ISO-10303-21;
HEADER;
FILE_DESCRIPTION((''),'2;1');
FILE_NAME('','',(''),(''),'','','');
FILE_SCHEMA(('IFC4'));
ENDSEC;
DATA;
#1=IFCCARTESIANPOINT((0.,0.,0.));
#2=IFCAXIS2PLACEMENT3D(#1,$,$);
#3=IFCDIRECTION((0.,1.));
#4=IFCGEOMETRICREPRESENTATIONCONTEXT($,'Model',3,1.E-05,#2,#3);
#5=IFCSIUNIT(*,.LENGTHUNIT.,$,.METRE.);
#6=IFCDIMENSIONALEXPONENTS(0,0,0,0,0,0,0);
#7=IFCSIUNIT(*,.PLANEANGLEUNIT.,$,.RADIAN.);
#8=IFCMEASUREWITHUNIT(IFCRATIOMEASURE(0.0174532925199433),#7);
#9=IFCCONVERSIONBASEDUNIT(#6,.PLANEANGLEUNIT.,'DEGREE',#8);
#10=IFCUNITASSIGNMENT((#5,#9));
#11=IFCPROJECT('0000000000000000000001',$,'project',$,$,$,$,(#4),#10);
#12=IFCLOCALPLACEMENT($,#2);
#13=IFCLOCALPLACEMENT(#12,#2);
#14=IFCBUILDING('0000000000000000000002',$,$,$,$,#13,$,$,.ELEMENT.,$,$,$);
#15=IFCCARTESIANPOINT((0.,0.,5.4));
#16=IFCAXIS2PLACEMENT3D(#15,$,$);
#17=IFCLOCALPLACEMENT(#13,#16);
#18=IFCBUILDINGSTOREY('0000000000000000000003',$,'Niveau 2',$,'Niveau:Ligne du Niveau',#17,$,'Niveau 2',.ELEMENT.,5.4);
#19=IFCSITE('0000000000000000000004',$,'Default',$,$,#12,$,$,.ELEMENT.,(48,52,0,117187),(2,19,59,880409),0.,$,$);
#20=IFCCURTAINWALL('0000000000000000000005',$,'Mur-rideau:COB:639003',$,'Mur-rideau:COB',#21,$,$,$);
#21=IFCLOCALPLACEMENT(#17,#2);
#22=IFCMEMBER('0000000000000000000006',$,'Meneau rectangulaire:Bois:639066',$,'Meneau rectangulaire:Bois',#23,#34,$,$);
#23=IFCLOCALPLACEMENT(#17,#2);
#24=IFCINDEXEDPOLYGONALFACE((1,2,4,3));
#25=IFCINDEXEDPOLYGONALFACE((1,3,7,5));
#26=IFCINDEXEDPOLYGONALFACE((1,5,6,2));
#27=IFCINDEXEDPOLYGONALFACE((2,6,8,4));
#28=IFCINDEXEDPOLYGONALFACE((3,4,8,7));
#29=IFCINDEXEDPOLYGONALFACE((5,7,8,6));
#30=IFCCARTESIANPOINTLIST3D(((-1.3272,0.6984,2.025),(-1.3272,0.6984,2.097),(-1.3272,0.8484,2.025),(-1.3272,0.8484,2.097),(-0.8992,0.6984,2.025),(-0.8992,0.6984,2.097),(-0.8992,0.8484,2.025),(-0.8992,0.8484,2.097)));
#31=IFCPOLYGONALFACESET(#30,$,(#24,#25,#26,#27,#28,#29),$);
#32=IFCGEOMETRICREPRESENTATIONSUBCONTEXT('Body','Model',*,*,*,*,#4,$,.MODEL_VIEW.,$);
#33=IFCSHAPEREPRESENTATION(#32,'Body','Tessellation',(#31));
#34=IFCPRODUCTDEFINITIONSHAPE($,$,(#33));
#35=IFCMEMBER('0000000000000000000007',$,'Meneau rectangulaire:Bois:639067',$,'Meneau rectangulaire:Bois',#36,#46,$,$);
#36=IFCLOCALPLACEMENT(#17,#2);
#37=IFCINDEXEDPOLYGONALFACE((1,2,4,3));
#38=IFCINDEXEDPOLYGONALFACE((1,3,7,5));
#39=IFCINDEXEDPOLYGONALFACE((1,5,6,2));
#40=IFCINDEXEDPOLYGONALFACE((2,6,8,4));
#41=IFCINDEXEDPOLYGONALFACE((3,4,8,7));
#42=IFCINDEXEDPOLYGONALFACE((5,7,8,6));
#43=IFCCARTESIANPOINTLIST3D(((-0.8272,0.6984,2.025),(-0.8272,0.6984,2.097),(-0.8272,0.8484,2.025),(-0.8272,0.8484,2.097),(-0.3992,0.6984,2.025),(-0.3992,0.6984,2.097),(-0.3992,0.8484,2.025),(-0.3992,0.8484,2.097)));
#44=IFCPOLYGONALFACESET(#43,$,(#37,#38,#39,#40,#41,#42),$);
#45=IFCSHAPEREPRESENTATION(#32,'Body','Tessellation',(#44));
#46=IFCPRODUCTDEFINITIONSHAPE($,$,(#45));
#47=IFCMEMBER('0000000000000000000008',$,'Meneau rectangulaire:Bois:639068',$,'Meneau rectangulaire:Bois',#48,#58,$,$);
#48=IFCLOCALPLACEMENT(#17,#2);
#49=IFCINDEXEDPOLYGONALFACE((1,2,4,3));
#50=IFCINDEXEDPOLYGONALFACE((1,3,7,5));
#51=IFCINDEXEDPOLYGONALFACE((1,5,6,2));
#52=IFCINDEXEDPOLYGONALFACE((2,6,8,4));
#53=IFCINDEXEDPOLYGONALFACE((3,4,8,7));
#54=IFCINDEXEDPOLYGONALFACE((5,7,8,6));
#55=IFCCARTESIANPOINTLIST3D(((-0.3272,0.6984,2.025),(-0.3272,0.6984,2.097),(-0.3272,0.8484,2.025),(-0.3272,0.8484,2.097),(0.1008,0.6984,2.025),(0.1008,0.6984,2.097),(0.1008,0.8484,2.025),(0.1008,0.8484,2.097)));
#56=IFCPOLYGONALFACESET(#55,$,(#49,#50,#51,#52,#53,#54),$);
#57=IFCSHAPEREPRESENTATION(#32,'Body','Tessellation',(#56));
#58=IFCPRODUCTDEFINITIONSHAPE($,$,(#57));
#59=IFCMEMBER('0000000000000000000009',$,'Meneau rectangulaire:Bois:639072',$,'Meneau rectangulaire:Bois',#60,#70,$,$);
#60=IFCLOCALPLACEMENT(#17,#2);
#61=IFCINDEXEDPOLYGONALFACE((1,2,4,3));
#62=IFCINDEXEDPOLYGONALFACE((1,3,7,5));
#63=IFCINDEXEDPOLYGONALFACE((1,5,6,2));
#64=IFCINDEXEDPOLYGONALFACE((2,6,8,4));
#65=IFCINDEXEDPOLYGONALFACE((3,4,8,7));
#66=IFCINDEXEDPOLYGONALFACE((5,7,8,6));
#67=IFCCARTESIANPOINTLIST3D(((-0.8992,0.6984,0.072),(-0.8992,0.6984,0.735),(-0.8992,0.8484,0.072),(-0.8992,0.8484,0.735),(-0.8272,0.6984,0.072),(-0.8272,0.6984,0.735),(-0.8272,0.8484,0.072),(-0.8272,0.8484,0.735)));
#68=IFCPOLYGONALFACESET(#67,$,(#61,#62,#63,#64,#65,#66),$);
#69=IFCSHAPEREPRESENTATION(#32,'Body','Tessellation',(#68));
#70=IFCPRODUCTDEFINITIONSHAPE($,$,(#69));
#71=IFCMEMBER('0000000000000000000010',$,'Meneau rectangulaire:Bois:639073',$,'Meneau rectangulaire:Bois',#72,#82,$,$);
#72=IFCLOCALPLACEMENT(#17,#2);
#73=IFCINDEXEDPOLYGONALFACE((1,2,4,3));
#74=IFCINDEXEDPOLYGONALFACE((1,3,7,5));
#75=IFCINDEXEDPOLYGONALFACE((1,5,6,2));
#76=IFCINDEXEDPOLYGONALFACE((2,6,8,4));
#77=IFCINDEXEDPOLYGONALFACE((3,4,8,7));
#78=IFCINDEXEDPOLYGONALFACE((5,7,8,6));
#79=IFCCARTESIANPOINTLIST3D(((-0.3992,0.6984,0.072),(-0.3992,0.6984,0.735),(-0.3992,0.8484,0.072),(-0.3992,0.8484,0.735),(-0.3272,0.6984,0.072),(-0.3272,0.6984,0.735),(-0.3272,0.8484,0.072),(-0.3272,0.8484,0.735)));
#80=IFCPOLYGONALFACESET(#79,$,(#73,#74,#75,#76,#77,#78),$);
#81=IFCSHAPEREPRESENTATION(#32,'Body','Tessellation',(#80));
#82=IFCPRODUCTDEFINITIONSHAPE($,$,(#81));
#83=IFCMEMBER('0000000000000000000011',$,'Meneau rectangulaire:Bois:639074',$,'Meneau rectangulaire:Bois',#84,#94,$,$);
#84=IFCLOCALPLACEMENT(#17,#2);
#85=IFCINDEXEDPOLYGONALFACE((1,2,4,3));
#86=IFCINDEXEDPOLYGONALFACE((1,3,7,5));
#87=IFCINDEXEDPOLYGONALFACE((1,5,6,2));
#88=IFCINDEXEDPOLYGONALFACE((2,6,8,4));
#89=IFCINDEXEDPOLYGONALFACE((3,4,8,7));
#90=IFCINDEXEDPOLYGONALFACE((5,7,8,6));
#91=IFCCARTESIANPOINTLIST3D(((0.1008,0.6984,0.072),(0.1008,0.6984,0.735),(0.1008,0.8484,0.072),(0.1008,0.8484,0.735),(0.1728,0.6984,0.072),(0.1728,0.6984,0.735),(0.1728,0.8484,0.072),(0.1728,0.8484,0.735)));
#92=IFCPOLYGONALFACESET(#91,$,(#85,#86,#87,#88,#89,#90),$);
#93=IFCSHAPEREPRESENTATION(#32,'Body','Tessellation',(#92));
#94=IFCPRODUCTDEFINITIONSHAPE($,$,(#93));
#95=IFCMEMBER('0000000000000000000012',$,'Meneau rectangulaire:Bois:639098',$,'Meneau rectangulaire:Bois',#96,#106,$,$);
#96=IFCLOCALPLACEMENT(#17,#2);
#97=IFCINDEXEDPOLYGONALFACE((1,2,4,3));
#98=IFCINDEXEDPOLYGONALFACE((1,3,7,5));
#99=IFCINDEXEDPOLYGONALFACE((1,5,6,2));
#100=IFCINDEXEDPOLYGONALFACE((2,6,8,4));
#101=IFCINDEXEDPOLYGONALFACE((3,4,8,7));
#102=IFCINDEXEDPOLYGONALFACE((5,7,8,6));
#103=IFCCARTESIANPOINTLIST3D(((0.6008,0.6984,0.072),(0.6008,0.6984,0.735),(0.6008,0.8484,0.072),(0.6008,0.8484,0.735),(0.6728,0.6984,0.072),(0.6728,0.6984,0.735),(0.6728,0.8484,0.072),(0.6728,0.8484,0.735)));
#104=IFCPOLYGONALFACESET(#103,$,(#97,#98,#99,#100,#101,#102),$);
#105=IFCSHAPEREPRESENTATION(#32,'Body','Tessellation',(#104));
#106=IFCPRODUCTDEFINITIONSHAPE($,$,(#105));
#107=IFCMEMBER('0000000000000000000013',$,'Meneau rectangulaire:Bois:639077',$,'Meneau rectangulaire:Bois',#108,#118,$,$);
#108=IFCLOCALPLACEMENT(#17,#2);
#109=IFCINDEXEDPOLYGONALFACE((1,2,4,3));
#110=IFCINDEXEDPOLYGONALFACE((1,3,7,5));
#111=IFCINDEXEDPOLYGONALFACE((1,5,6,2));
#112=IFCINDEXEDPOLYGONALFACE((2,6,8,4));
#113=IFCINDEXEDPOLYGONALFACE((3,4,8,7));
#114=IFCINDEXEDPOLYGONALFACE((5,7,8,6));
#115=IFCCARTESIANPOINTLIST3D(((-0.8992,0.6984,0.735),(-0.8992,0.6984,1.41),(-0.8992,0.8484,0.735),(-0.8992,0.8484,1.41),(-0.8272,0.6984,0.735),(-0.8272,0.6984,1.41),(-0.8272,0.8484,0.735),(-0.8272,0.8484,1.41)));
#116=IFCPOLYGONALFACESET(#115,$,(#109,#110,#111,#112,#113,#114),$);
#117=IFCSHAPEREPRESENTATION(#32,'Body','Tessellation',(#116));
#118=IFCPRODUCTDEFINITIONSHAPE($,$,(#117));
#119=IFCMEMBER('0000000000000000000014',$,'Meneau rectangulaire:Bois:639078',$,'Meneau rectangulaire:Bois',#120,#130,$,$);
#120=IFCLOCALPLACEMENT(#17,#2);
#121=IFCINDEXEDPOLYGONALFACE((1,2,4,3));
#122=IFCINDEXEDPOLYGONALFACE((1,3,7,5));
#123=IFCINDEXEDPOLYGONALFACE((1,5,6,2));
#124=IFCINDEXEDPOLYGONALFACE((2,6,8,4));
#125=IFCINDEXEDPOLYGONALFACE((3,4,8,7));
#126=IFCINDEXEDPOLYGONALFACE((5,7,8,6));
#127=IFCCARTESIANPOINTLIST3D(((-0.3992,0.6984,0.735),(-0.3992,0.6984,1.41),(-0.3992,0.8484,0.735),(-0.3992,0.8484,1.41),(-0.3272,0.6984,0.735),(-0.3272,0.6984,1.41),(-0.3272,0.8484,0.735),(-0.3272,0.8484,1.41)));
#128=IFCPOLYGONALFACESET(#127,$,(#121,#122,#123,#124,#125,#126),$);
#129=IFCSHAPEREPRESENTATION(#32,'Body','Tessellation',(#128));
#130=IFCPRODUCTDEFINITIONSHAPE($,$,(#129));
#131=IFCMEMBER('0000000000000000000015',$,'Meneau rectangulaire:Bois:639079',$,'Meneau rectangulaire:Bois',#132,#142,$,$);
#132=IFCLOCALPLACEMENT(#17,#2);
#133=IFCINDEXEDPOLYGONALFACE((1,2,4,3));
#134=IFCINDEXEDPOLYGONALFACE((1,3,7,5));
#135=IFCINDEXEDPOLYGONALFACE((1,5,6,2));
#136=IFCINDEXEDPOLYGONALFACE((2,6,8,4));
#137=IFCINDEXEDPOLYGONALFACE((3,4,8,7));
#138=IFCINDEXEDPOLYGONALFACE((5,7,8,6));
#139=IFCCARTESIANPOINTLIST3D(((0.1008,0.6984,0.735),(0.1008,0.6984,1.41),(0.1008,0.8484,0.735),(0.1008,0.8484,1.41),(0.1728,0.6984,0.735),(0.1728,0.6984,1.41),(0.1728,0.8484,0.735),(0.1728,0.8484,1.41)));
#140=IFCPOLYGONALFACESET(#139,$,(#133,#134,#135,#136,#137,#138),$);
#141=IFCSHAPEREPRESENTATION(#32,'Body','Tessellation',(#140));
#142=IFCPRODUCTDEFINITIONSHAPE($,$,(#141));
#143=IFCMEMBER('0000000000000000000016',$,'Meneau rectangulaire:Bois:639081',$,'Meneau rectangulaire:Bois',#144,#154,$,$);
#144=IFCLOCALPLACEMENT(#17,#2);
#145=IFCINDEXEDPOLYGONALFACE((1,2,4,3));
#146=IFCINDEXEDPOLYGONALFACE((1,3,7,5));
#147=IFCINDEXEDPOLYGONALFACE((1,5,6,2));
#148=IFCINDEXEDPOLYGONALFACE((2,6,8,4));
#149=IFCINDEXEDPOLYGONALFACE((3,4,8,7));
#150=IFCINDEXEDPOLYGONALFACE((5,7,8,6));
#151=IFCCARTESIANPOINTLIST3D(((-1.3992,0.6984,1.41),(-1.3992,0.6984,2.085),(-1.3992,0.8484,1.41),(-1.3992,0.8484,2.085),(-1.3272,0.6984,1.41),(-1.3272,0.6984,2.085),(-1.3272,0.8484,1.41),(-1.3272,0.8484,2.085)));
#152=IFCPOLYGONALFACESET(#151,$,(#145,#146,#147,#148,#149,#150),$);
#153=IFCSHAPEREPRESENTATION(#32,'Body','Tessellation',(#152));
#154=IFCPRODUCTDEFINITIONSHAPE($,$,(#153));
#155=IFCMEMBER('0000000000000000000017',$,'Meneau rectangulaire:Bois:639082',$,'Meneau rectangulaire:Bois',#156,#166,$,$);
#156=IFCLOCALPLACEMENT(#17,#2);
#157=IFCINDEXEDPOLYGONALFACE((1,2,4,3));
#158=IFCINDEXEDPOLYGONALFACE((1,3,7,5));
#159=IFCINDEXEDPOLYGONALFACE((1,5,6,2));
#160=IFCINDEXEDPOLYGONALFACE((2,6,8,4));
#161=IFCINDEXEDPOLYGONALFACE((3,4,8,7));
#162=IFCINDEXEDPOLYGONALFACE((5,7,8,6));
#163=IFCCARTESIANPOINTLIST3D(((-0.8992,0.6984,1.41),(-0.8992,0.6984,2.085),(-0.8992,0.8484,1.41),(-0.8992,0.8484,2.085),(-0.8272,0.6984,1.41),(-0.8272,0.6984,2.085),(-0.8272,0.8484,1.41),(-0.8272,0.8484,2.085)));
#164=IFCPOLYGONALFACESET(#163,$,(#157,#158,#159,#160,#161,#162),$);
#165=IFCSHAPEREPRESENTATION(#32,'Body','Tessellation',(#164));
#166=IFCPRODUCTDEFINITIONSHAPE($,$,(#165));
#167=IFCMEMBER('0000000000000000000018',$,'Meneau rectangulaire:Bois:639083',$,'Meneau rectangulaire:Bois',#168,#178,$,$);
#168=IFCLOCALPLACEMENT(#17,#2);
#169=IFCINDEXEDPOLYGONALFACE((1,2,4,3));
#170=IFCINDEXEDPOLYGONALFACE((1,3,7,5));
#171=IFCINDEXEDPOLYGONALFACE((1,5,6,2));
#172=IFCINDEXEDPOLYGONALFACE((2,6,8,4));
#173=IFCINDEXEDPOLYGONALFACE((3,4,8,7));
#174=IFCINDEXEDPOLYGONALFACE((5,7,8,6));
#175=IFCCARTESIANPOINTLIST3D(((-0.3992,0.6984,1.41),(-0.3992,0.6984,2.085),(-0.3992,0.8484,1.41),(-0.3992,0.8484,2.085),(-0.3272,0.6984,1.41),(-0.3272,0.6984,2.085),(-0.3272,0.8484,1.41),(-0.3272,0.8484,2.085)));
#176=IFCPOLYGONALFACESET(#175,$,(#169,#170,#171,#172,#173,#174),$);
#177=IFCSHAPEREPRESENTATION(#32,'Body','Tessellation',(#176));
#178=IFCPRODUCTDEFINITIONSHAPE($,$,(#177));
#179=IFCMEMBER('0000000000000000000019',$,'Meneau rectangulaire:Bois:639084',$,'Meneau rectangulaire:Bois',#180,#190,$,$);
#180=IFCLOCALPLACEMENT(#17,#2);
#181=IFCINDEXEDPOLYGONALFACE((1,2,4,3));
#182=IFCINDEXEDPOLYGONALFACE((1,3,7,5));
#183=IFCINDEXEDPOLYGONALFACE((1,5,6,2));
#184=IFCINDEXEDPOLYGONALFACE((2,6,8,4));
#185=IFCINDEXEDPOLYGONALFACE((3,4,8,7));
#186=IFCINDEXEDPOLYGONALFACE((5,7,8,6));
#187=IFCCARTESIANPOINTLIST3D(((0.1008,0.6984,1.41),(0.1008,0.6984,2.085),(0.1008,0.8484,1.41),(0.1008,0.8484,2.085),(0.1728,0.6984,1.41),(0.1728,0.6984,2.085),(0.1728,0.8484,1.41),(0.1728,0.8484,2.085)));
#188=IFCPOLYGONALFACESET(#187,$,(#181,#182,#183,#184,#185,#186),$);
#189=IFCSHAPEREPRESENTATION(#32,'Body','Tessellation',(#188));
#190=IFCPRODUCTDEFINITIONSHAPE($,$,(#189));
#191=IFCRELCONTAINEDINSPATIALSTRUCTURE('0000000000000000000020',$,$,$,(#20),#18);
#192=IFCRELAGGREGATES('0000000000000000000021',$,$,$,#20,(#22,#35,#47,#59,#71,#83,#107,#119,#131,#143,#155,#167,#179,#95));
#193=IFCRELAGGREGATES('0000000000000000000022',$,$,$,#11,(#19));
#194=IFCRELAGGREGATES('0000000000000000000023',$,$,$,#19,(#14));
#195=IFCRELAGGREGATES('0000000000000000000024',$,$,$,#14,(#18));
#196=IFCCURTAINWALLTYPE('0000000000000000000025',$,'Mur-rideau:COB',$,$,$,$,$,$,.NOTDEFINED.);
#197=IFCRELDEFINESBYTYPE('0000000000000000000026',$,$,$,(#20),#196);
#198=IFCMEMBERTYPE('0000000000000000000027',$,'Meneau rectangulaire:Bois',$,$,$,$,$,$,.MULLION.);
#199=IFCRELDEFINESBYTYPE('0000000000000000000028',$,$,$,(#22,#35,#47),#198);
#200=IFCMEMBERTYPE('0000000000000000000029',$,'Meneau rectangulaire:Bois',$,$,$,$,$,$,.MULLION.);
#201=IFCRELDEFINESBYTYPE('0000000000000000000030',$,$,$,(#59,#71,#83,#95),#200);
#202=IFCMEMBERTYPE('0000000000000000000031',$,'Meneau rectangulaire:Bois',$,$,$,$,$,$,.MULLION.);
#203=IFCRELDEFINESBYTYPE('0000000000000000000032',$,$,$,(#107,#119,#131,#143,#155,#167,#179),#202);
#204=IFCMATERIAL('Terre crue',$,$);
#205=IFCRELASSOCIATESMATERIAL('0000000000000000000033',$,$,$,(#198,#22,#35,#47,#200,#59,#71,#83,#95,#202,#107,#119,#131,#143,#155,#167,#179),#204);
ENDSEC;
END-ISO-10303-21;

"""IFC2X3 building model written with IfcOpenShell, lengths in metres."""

from ifc_helpers import new_model, entity, si_unit, converted_unit, direction, frame, origin, origin_2d_with_axis, place, context, subcontext, project, spatial, rectangle, extrude, source, transform, mapped, material, type_object, type_shapes, element, aggregate, save


model = new_model("IFC2X3")

# Units and contexts
model_context = context("Model", 3, precision=1e-05, world=origin(), true_north=direction((0.0, 1.0)))
body_context = subcontext(model_context, "Body", "Model", "MODEL_VIEW")
ifc_project = project(units=[si_unit("LENGTHUNIT", "METRE"), converted_unit("PLANEANGLEUNIT", "DEGREE", entity("IfcRatioMeasure", 0.0174532925199433), si_unit("PLANEANGLEUNIT", "RADIAN"), dimensions=[0, 0, 0, 0, 0, 0, 0])], contexts=[model_context])

# Site, building, storey
site_placement = place(None, origin())
site = spatial("IfcSite", under=ifc_project, at=site_placement, Name="Default", CompositionType="ELEMENT", RefLatitude=(48, 52, 0, 117187), RefLongitude=(2, 19, 59, 880409), RefElevation=0.0)
building_placement = place(site_placement, origin())
building = spatial("IfcBuilding", under=site, at=building_placement, CompositionType="ELEMENT")
storey_placement = place(building_placement, frame((0.0, 0.0, 5.4)))
storey = spatial("IfcBuildingStorey", under=building, at=storey_placement, Name="Niveau 2", ObjectType="Niveau:Ligne du Niveau", LongName="Niveau 2", CompositionType="ELEMENT", Elevation=5.4)

# Curtain wall, members
curtain_wall_type_1 = type_object("IfcCurtainWallType", Name="Mur-rideau:COB", PredefinedType="NOTDEFINED")
curtain_wall_1_placement = place(storey_placement, frame((0.0, 0.0, -5.4)))
curtain_wall_1 = element("IfcCurtainWall", 1, at=curtain_wall_1_placement, inside=storey, type_object=curtain_wall_type_1, Name="Mur-rideau:COB:639003", ObjectType="Mur-rideau:COB")
ifc_material_1 = material(Name="Terre crue")
member_type_1 = type_object("IfcMemberType", Name="Meneau rectangulaire:Bois", PredefinedType="MULLION", material=ifc_material_1)
shared_shape_1 = source(origin(), body_context, "Body", "SweptSolid", [
    extrude(rectangle(XDim=0.15, YDim=0.072, at=origin_2d_with_axis()), frame((-0.024, 0.0, -0.428), z_axis=(0.0, 0.0, 1.0), x_axis=(0.0, -1.0, 0.0)), (0.0, 0.0, 1.0), 0.428),
])
type_shapes(member_type_1, [shared_shape_1])
member_1_placement = place(storey_placement, frame((-0.8992, 0.7734, 2.085), z_axis=(1.0, 0.0, 0.0), x_axis=(0.0, 0.0, 1.0)))
member_1 = element("IfcMember", 2, at=member_1_placement, type_object=member_type_1, material=ifc_material_1, Name="Meneau rectangulaire:Bois:639066", ObjectType="Meneau rectangulaire:Bois", context=body_context, shape_type="MappedRepresentation", body=[
    mapped(shared_shape_1, transform((0.0, 0.0, 0.0), scale=1.0)),
])
member_2_placement = place(storey_placement, frame((-0.3992, 0.7734, 2.085), z_axis=(1.0, 0.0, 0.0), x_axis=(0.0, 0.0, 1.0)))
member_2 = element("IfcMember", 3, at=member_2_placement, type_object=member_type_1, material=ifc_material_1, Name="Meneau rectangulaire:Bois:639067", ObjectType="Meneau rectangulaire:Bois", context=body_context, shape_type="MappedRepresentation", body=[
    mapped(shared_shape_1, transform((0.0, 0.0, 0.0), scale=1.0)),
])
member_3_placement = place(storey_placement, frame((0.1008, 0.7734, 2.085), z_axis=(1.0, 0.0, 0.0), x_axis=(0.0, 0.0, 1.0)))
member_3 = element("IfcMember", 4, at=member_3_placement, type_object=member_type_1, material=ifc_material_1, Name="Meneau rectangulaire:Bois:639068", ObjectType="Meneau rectangulaire:Bois", context=body_context, shape_type="MappedRepresentation", body=[
    mapped(shared_shape_1, transform((0.0, 0.0, 0.0), scale=1.0)),
])
member_type_2 = type_object("IfcMemberType", Name="Meneau rectangulaire:Bois", PredefinedType="MULLION", material=ifc_material_1)
shared_shape_2 = source(origin(), body_context, "Body", "SweptSolid", [
    extrude(rectangle(XDim=0.15, YDim=0.072, at=origin_2d_with_axis()), frame((-0.024, 0.0, -0.663), z_axis=(0.0, 0.0, 1.0), x_axis=(0.0, -1.0, 0.0)), (0.0, 0.0, 1.0), 0.663),
])
type_shapes(member_type_2, [shared_shape_2])
member_4_placement = place(storey_placement, frame((-0.8392, 0.7734, 0.072), z_axis=(0.0, 0.0, -1.0), x_axis=(1.0, 0.0, 0.0)))
member_4 = element("IfcMember", 5, at=member_4_placement, type_object=member_type_2, material=ifc_material_1, Name="Meneau rectangulaire:Bois:639072", ObjectType="Meneau rectangulaire:Bois", context=body_context, shape_type="MappedRepresentation", body=[
    mapped(shared_shape_2, transform((0.0, 0.0, 0.0), scale=1.0)),
])
member_5_placement = place(storey_placement, frame((-0.3392, 0.7734, 0.072), z_axis=(0.0, 0.0, -1.0), x_axis=(1.0, 0.0, 0.0)))
member_5 = element("IfcMember", 6, at=member_5_placement, type_object=member_type_2, material=ifc_material_1, Name="Meneau rectangulaire:Bois:639073", ObjectType="Meneau rectangulaire:Bois", context=body_context, shape_type="MappedRepresentation", body=[
    mapped(shared_shape_2, transform((0.0, 0.0, 0.0), scale=1.0)),
])
member_6_placement = place(storey_placement, frame((0.1608, 0.7734, 0.072), z_axis=(0.0, 0.0, -1.0), x_axis=(1.0, 0.0, 0.0)))
member_6 = element("IfcMember", 7, at=member_6_placement, type_object=member_type_2, material=ifc_material_1, Name="Meneau rectangulaire:Bois:639074", ObjectType="Meneau rectangulaire:Bois", context=body_context, shape_type="MappedRepresentation", body=[
    mapped(shared_shape_2, transform((0.0, 0.0, 0.0), scale=1.0)),
])
member_7_placement = place(storey_placement, frame((0.6608, 0.7734, 0.072), z_axis=(0.0, 0.0, -1.0), x_axis=(1.0, 0.0, 0.0)))
member_7 = element("IfcMember", 8, at=member_7_placement, type_object=member_type_2, material=ifc_material_1, Name="Meneau rectangulaire:Bois:639098", ObjectType="Meneau rectangulaire:Bois", context=body_context, shape_type="MappedRepresentation", body=[
    mapped(shared_shape_2, transform((0.0, 0.0, 0.0), scale=1.0)),
])
member_type_3 = type_object("IfcMemberType", Name="Meneau rectangulaire:Bois", PredefinedType="MULLION", material=ifc_material_1)
shared_shape_3 = source(origin(), body_context, "Body", "SweptSolid", [
    extrude(rectangle(XDim=0.15, YDim=0.072, at=origin_2d_with_axis()), frame((-0.024, 0.0, -0.675), z_axis=(0.0, 0.0, 1.0), x_axis=(0.0, -1.0, 0.0)), (0.0, 0.0, 1.0), 0.675),
])
type_shapes(member_type_3, [shared_shape_3])
member_8_placement = place(storey_placement, frame((-0.8392, 0.7734, 0.735), z_axis=(0.0, 0.0, -1.0), x_axis=(1.0, 0.0, 0.0)))
member_8 = element("IfcMember", 9, at=member_8_placement, type_object=member_type_3, material=ifc_material_1, Name="Meneau rectangulaire:Bois:639077", ObjectType="Meneau rectangulaire:Bois", context=body_context, shape_type="MappedRepresentation", body=[
    mapped(shared_shape_3, transform((0.0, 0.0, 0.0), scale=1.0)),
])
member_9_placement = place(storey_placement, frame((-0.3392, 0.7734, 0.735), z_axis=(0.0, 0.0, -1.0), x_axis=(1.0, 0.0, 0.0)))
member_9 = element("IfcMember", 10, at=member_9_placement, type_object=member_type_3, material=ifc_material_1, Name="Meneau rectangulaire:Bois:639078", ObjectType="Meneau rectangulaire:Bois", context=body_context, shape_type="MappedRepresentation", body=[
    mapped(shared_shape_3, transform((0.0, 0.0, 0.0), scale=1.0)),
])
member_10_placement = place(storey_placement, frame((0.1608, 0.7734, 0.735), z_axis=(0.0, 0.0, -1.0), x_axis=(1.0, 0.0, 0.0)))
member_10 = element("IfcMember", 11, at=member_10_placement, type_object=member_type_3, material=ifc_material_1, Name="Meneau rectangulaire:Bois:639079", ObjectType="Meneau rectangulaire:Bois", context=body_context, shape_type="MappedRepresentation", body=[
    mapped(shared_shape_3, transform((0.0, 0.0, 0.0), scale=1.0)),
])
member_11_placement = place(storey_placement, frame((-1.3392, 0.7734, 1.41), z_axis=(0.0, 0.0, -1.0), x_axis=(1.0, 0.0, 0.0)))
member_11 = element("IfcMember", 12, at=member_11_placement, type_object=member_type_3, material=ifc_material_1, Name="Meneau rectangulaire:Bois:639081", ObjectType="Meneau rectangulaire:Bois", context=body_context, shape_type="MappedRepresentation", body=[
    mapped(shared_shape_3, transform((0.0, 0.0, 0.0), scale=1.0)),
])
member_12_placement = place(storey_placement, frame((-0.8392, 0.7734, 1.41), z_axis=(0.0, 0.0, -1.0), x_axis=(1.0, 0.0, 0.0)))
member_12 = element("IfcMember", 13, at=member_12_placement, type_object=member_type_3, material=ifc_material_1, Name="Meneau rectangulaire:Bois:639082", ObjectType="Meneau rectangulaire:Bois", context=body_context, shape_type="MappedRepresentation", body=[
    mapped(shared_shape_3, transform((0.0, 0.0, 0.0), scale=1.0)),
])
member_13_placement = place(storey_placement, frame((-0.3392, 0.7734, 1.41), z_axis=(0.0, 0.0, -1.0), x_axis=(1.0, 0.0, 0.0)))
member_13 = element("IfcMember", 14, at=member_13_placement, type_object=member_type_3, material=ifc_material_1, Name="Meneau rectangulaire:Bois:639083", ObjectType="Meneau rectangulaire:Bois", context=body_context, shape_type="MappedRepresentation", body=[
    mapped(shared_shape_3, transform((0.0, 0.0, 0.0), scale=1.0)),
])
member_14_placement = place(storey_placement, frame((0.1608, 0.7734, 1.41), z_axis=(0.0, 0.0, -1.0), x_axis=(1.0, 0.0, 0.0)))
member_14 = element("IfcMember", 15, at=member_14_placement, type_object=member_type_3, material=ifc_material_1, Name="Meneau rectangulaire:Bois:639084", ObjectType="Meneau rectangulaire:Bois", context=body_context, shape_type="MappedRepresentation", body=[
    mapped(shared_shape_3, transform((0.0, 0.0, 0.0), scale=1.0)),
])
aggregate(curtain_wall_1, [member_1, member_2, member_3, member_4, member_5, member_6, member_8, member_9, member_10, member_11, member_12, member_13, member_14, member_7])

save(model, "model.ifc")
